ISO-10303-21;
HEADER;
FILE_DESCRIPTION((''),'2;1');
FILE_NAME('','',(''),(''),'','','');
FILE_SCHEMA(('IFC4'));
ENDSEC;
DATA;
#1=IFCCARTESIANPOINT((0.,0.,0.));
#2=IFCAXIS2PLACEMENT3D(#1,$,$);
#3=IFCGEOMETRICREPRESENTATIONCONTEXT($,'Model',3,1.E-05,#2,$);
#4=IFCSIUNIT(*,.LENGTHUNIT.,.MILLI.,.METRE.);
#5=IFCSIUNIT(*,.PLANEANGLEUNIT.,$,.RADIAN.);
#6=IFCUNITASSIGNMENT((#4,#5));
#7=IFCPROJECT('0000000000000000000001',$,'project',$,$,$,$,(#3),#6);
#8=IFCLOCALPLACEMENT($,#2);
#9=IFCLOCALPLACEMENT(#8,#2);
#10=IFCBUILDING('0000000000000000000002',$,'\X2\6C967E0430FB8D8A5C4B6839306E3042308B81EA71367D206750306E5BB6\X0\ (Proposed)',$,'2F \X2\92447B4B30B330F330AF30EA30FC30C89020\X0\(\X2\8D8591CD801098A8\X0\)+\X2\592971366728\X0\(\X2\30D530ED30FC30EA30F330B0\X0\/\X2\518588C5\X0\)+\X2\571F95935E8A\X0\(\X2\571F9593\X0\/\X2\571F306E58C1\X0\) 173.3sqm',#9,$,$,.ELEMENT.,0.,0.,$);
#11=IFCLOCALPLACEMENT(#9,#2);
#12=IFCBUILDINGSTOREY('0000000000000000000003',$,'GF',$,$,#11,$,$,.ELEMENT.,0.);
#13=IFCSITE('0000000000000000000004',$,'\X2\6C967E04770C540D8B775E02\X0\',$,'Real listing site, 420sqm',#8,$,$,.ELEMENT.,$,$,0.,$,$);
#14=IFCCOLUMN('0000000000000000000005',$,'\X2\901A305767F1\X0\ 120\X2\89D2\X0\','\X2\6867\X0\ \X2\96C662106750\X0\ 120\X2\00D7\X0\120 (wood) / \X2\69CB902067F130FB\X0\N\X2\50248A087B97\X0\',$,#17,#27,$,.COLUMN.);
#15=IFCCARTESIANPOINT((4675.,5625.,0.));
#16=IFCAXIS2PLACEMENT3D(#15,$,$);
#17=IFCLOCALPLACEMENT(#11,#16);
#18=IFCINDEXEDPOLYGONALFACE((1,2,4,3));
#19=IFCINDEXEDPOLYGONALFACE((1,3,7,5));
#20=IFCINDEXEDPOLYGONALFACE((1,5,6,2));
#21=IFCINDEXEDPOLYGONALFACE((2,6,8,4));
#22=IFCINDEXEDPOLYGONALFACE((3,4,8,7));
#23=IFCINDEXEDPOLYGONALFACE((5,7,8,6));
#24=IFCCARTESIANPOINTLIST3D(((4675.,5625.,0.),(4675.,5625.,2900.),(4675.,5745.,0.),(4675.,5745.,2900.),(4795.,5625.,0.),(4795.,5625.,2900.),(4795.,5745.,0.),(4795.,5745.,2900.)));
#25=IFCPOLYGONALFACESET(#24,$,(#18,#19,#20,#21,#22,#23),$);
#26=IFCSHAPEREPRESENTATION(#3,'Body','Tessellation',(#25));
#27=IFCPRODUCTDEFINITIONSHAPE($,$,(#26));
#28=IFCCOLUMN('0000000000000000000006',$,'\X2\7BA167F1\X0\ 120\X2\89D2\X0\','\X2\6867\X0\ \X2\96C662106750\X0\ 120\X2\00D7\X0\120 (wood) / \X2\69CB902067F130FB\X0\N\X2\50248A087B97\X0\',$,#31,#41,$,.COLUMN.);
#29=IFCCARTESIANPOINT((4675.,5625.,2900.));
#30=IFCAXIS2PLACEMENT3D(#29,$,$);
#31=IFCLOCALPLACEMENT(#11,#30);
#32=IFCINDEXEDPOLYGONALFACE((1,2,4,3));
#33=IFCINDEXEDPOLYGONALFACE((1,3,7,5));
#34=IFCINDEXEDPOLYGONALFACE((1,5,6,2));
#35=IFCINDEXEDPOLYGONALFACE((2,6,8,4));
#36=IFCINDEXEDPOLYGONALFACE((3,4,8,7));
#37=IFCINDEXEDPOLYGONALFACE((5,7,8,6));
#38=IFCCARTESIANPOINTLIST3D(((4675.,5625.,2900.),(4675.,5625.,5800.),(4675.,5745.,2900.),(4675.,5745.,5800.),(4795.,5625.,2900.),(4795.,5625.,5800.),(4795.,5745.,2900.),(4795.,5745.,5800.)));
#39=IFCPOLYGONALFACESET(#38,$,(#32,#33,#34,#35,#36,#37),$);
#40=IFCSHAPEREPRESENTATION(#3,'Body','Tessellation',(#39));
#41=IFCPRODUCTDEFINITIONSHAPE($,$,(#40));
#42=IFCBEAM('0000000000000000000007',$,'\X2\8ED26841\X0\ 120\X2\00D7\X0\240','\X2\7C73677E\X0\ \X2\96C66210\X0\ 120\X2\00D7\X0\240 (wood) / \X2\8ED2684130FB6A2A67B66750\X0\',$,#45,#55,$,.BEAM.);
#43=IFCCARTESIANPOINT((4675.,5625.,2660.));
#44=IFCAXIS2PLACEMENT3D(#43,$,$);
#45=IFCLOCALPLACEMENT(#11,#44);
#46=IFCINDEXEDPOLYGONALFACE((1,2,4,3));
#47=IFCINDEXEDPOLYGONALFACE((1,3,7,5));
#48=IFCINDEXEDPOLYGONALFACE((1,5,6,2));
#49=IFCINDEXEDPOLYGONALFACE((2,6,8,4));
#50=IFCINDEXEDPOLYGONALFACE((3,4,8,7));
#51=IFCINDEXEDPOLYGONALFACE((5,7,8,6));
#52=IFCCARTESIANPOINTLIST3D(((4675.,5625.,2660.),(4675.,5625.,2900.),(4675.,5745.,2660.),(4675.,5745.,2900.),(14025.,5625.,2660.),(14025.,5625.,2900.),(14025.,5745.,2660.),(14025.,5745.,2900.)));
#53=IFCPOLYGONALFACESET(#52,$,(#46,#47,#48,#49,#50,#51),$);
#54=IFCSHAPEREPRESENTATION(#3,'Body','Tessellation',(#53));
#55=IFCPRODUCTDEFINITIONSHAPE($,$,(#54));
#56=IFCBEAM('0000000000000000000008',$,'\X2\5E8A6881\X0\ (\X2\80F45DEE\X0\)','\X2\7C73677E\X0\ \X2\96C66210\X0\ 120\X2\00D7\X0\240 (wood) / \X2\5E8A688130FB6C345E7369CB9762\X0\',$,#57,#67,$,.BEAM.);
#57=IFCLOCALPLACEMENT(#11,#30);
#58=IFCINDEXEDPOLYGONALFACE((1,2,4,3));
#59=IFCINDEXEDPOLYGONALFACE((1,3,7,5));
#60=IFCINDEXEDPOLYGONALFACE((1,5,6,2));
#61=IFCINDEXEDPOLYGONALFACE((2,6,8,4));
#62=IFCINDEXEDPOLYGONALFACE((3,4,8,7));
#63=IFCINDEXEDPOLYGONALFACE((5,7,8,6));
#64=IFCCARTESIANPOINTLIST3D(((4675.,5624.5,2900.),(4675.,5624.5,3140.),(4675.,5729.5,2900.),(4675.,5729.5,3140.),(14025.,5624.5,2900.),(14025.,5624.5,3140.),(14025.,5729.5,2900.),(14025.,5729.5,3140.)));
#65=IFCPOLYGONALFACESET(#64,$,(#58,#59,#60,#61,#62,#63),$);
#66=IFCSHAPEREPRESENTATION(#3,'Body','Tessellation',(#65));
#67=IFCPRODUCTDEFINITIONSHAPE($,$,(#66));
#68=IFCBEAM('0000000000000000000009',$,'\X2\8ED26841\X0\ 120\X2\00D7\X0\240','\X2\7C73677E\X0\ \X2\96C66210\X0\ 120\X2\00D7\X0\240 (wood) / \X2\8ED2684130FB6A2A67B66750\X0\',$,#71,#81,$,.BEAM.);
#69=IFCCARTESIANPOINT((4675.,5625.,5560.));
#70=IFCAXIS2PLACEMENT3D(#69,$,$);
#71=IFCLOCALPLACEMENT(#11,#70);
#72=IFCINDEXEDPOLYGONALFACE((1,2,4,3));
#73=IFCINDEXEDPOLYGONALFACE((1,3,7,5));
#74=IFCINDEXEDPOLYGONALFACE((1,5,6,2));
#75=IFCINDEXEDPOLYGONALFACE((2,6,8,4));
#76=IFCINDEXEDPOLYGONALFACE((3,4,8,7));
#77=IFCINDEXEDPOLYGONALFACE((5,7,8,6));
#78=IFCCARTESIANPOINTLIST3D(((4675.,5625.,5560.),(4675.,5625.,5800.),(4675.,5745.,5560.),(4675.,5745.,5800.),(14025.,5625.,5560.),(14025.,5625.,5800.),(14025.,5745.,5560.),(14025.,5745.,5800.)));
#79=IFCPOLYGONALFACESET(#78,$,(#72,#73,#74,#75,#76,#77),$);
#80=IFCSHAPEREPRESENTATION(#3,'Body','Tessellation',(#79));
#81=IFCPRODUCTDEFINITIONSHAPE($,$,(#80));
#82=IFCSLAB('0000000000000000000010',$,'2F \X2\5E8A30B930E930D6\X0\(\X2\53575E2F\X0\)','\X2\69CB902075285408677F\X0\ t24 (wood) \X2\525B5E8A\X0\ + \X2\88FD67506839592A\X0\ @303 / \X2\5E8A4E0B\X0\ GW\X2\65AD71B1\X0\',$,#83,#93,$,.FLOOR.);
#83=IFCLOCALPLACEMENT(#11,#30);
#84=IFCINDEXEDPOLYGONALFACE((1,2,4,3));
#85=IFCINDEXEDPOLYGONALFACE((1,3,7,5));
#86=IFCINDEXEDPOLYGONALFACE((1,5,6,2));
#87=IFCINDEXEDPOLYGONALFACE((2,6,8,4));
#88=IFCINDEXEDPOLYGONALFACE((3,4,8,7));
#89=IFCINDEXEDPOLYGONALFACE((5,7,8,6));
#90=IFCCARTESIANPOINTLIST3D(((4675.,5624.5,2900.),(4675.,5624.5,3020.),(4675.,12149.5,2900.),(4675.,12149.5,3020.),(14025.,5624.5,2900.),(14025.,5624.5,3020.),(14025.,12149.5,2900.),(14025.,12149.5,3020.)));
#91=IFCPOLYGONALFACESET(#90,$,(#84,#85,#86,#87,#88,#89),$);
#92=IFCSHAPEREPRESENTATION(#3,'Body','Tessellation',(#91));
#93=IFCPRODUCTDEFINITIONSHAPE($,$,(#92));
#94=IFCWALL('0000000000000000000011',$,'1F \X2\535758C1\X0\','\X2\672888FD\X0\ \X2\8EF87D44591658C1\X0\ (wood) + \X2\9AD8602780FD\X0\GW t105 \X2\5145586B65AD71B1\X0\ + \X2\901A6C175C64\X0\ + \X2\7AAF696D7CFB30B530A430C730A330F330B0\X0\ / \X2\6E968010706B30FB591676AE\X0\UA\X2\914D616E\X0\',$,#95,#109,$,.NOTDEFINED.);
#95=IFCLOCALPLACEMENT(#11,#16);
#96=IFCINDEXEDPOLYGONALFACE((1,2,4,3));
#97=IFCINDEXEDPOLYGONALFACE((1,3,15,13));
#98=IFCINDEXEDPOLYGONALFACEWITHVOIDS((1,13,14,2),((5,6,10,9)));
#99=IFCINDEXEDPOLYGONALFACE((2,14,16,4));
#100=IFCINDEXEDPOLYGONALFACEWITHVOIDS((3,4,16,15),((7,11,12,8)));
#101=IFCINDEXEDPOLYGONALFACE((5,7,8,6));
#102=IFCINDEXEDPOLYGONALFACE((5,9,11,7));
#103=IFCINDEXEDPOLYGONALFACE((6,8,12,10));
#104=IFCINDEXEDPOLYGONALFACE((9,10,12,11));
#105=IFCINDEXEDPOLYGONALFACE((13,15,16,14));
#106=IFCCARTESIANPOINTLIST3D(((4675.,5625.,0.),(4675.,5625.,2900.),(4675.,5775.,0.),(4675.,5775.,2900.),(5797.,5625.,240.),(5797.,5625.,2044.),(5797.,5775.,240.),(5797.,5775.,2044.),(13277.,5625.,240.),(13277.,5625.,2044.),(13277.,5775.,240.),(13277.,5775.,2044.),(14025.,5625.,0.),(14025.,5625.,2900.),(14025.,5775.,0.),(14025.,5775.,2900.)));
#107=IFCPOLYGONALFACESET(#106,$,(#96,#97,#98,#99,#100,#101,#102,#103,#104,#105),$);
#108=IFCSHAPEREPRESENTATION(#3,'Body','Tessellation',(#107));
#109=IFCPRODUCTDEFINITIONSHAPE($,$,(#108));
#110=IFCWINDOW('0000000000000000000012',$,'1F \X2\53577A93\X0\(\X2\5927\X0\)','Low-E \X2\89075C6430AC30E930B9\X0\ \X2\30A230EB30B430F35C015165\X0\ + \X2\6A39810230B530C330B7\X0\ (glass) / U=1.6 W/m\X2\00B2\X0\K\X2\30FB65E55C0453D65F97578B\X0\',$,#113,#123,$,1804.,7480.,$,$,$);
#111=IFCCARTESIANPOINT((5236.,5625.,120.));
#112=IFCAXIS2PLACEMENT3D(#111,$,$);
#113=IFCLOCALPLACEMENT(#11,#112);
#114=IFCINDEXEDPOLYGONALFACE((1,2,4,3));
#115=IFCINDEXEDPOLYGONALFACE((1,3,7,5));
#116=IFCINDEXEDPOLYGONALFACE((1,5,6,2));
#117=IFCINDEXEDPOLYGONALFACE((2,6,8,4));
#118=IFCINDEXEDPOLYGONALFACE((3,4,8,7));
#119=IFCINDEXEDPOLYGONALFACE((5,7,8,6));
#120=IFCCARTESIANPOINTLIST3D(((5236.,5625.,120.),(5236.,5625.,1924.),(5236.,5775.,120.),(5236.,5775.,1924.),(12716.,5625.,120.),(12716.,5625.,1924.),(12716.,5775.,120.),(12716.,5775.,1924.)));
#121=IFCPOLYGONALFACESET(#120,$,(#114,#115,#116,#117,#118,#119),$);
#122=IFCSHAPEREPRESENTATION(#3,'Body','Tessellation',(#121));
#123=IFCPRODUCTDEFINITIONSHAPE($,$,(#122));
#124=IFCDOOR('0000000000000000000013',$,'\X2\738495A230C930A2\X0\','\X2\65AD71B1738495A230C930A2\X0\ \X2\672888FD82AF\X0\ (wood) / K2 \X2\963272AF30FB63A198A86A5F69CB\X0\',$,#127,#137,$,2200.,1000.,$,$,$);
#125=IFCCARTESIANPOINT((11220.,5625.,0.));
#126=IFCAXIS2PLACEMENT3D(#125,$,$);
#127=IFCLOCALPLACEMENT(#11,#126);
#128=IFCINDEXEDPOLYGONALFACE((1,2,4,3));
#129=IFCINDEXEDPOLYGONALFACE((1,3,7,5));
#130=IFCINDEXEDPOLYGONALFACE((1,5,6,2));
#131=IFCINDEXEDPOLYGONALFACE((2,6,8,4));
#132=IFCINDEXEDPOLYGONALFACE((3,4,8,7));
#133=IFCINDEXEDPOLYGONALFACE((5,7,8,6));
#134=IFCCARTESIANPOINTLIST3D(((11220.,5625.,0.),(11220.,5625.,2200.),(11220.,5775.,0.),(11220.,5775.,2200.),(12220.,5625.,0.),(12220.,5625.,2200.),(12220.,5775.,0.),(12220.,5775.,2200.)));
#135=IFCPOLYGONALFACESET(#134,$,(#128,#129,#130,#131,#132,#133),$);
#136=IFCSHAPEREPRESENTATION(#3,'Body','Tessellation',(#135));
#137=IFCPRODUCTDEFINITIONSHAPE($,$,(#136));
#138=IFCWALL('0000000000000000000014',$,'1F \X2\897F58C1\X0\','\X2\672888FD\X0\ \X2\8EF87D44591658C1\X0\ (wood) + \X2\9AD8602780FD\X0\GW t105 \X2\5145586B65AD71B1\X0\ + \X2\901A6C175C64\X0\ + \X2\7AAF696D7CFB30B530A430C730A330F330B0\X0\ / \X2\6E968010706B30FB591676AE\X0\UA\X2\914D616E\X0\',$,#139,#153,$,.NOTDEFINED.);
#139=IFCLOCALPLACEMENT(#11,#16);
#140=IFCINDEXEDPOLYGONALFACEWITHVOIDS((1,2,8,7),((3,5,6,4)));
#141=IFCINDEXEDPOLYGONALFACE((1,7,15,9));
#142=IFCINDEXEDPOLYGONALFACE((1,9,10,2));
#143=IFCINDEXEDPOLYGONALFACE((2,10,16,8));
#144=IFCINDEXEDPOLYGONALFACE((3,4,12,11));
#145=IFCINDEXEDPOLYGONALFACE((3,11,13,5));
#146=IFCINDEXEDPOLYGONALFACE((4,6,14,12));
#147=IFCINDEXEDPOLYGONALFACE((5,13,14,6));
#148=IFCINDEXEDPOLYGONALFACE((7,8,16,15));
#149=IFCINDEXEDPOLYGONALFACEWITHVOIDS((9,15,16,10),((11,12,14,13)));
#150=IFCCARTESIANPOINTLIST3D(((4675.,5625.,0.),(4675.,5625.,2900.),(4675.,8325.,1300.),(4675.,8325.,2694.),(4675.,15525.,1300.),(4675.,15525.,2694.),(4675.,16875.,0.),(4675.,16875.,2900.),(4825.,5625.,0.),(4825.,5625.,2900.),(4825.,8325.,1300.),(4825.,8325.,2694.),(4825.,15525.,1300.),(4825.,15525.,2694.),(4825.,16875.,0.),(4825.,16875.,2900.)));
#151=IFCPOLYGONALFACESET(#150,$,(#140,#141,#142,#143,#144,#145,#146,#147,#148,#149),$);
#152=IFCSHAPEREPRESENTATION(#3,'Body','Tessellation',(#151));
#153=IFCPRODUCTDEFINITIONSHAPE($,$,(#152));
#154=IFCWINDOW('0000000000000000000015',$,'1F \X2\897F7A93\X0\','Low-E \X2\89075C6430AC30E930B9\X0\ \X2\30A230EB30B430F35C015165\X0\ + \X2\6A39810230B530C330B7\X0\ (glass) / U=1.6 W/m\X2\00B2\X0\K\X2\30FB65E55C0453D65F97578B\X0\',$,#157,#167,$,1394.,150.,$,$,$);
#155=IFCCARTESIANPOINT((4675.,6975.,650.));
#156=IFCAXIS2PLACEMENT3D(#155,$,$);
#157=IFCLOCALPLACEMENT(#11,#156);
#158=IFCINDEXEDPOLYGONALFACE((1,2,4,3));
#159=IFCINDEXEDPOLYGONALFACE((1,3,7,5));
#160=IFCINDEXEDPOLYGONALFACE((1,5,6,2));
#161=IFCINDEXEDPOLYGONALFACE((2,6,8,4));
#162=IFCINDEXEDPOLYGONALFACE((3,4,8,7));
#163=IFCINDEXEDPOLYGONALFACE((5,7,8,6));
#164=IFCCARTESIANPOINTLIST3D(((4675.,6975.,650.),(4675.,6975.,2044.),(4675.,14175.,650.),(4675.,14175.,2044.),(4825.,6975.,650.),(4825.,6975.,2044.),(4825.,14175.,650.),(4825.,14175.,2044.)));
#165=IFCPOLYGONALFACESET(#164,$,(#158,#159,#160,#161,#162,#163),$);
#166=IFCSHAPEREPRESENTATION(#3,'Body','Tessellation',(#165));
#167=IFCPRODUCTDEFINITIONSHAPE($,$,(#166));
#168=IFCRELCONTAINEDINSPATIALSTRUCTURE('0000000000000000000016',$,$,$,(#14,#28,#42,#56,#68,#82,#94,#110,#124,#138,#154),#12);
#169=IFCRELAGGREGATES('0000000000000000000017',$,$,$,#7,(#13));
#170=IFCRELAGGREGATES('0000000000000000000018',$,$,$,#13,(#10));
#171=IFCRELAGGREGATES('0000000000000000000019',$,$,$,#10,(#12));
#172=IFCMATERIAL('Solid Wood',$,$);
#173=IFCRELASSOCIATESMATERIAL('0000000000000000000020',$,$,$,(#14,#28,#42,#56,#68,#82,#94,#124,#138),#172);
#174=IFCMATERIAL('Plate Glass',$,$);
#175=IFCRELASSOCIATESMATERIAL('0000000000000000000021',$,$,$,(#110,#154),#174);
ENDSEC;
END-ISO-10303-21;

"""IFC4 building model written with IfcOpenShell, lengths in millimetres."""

from ifc_helpers import new_model, si_unit, frame, frame_2d, origin, place, context, project, spatial, rectangle, extrude, material, element, fill, save


model = new_model("IFC4")

# Units and contexts
model_context = context("Model", 3, precision=1e-05, world=origin())
ifc_project = project(units=[si_unit("LENGTHUNIT", "METRE", prefix="MILLI"), si_unit("PLANEANGLEUNIT", "RADIAN")], contexts=[model_context])

# Site, building, storey
site_placement = place(None, origin())
site = spatial("IfcSite", under=ifc_project, at=site_placement, Name="沖縄県名護市", ObjectType="Real listing site, 420sqm", CompositionType="ELEMENT", RefElevation=0.0)
building_placement = place(site_placement, origin())
building = spatial("IfcBuilding", under=site, at=building_placement, Name="沖縄・越屋根のある自然素材の家 (Proposed)", ObjectType="2F 鉄筋コンクリート造(超重耐風)+天然木(フローリング/内装)+土間床(土間/土の壁) 173.3sqm", CompositionType="ELEMENT", ElevationOfRefHeight=0.0, ElevationOfTerrain=0.0)
storey_placement = place(building_placement, origin())
storey = spatial("IfcBuildingStorey", under=building, at=storey_placement, Name="GF", CompositionType="ELEMENT", Elevation=0.0)

# Columns
ifc_material_1 = material(Name="Solid Wood")
column_1_placement = place(storey_placement, frame((4675.0, 5625.0, 0.0)))
element("IfcColumn", 1, at=column_1_placement, inside=storey, material=ifc_material_1, Name="通し柱 120角", Description="桧 集成材 120×120 (wood) / 構造柱・N値計算", PredefinedType="COLUMN", context=model_context, shape_type="SweptSolid", body=[
    extrude(rectangle(XDim=120.0, YDim=120.0, at=frame_2d((60.0, 60.0))), frame((4675.0, 5625.0, 0.0)), (0.0, 0.0, 1.0), 2900.0),
])
column_2_placement = place(storey_placement, frame((4675.0, 5625.0, 2900.0)))
element("IfcColumn", 2, at=column_2_placement, inside=storey, material=ifc_material_1, Name="管柱 120角", Description="桧 集成材 120×120 (wood) / 構造柱・N値計算", PredefinedType="COLUMN", context=model_context, shape_type="SweptSolid", body=[
    extrude(rectangle(XDim=120.0, YDim=120.0, at=frame_2d((60.0, 60.0))), frame((4675.0, 5625.0, 2900.0)), (0.0, 0.0, 1.0), 2900.0),
])

# Beams
beam_1_placement = place(storey_placement, frame((4675.0, 5625.0, 2660.0)))
element("IfcBeam", 3, at=beam_1_placement, inside=storey, material=ifc_material_1, Name="軒桁 120×240", Description="米松 集成 120×240 (wood) / 軒桁・横架材", PredefinedType="BEAM", context=model_context, shape_type="SweptSolid", body=[
    extrude(rectangle(XDim=9350.0, YDim=120.0, at=frame_2d((4675.0, 60.0))), frame((4675.0, 5625.0, 2660.0)), (0.0, 0.0, 1.0), 240.0),
])
beam_2_placement = place(storey_placement, frame((4675.0, 5625.0, 2900.0)))
element("IfcBeam", 4, at=beam_2_placement, inside=storey, material=ifc_material_1, Name="床梁 (胴差)", Description="米松 集成 120×240 (wood) / 床梁・水平構面", PredefinedType="BEAM", context=model_context, shape_type="SweptSolid", body=[
    extrude(rectangle(XDim=9350.0, YDim=105.0, at=frame_2d((4675.0, 52.0))), frame((4675.0, 5625.0, 2900.0)), (0.0, 0.0, 1.0), 240.0),
])
beam_3_placement = place(storey_placement, frame((4675.0, 5625.0, 5560.0)))
element("IfcBeam", 5, at=beam_3_placement, inside=storey, material=ifc_material_1, Name="軒桁 120×240", Description="米松 集成 120×240 (wood) / 軒桁・横架材", PredefinedType="BEAM", context=model_context, shape_type="SweptSolid", body=[
    extrude(rectangle(XDim=9350.0, YDim=120.0, at=frame_2d((4675.0, 60.0))), frame((4675.0, 5625.0, 5560.0)), (0.0, 0.0, 1.0), 240.0),
])

# Slab
slab_1_placement = place(storey_placement, frame((4675.0, 5625.0, 2900.0)))
element("IfcSlab", 6, at=slab_1_placement, inside=storey, material=ifc_material_1, Name="2F 床スラブ(南帯)", Description="構造用合板 t24 (wood) 剛床 + 製材根太 @303 / 床下 GW断熱", PredefinedType="FLOOR", context=model_context, shape_type="SweptSolid", body=[
    extrude(rectangle(XDim=9350.0, YDim=6525.0, at=frame_2d((4675.0, 3262.0))), frame((4675.0, 5625.0, 2900.0)), (0.0, 0.0, 1.0), 120.0),
])

# Wall, openings, window, door
wall_1_placement = place(storey_placement, frame((4675.0, 5625.0, 0.0)))
wall_1 = element("IfcWall", 7, at=wall_1_placement, inside=storey, material=ifc_material_1, Name="1F 南壁", Description="木製 軸組外壁 (wood) + 高性能GW t105 充填断熱 + 通気層 + 窯業系サイディング / 準耐火・外皮UA配慮", PredefinedType="NOTDEFINED", context=model_context, shape_type="SweptSolid", body=[
    extrude(rectangle(XDim=9350.0, YDim=150.0, at=frame_2d((4675.0, 75.0))), frame((4675.0, 5625.0, 0.0)), (0.0, 0.0, 1.0), 2900.0),
])
opening_1_placement = place(storey_placement, frame((5236.0, 5625.0, 120.0)))
opening_1 = element("IfcOpeningElement", 8, at=opening_1_placement, cuts=wall_1, PredefinedType="NOTDEFINED", context=model_context, shape_type="SweptSolid", body=[
    extrude(rectangle(XDim=7480.0, YDim=150.0, at=frame_2d((3740.0, 75.0))), frame((5236.0, 5625.0, 120.0)), (0.0, 0.0, 1.0), 1804.0),
])
opening_2_placement = place(storey_placement, frame((11220.0, 5625.0, 0.0)))
opening_2 = element("IfcOpeningElement", 9, at=opening_2_placement, cuts=wall_1, PredefinedType="NOTDEFINED", context=model_context, shape_type="SweptSolid", body=[
    extrude(rectangle(XDim=1000.0, YDim=150.0, at=frame_2d((500.0, 75.0))), frame((11220.0, 5625.0, 0.0)), (0.0, 0.0, 1.0), 2200.0),
])
ifc_material_2 = material(Name="Plate Glass")
window_1_placement = place(storey_placement, frame((5236.0, 5625.0, 120.0)))
window_1 = element("IfcWindow", 10, at=window_1_placement, inside=storey, material=ifc_material_2, Name="1F 南窓(大)", Description="Low-E 複層ガラス アルゴン封入 + 樹脂サッシ (glass) / U=1.6 W/m²K・日射取得型", OverallHeight=1804.0, OverallWidth=7480.0, context=model_context, shape_type="SweptSolid", body=[
    extrude(rectangle(XDim=7480.0, YDim=150.0, at=frame_2d((3740.0, 75.0))), frame((5236.0, 5625.0, 120.0)), (0.0, 0.0, 1.0), 1804.0),
])
fill(opening_1, window_1)
door_placement = place(storey_placement, frame((11220.0, 5625.0, 0.0)))
door = element("IfcDoor", 11, at=door_placement, inside=storey, material=ifc_material_1, Name="玄関ドア", Description="断熱玄関ドア 木製芯 (wood) / K2 防犯・採風機構", OverallHeight=2200.0, OverallWidth=1000.0, context=model_context, shape_type="SweptSolid", body=[
    extrude(rectangle(XDim=1000.0, YDim=150.0, at=frame_2d((500.0, 75.0))), frame((11220.0, 5625.0, 0.0)), (0.0, 0.0, 1.0), 2200.0),
])
fill(opening_2, door)

# Wall, opening, window
wall_2_placement = place(storey_placement, frame((4675.0, 5625.0, 0.0)))
wall_2 = element("IfcWall", 12, at=wall_2_placement, inside=storey, material=ifc_material_1, Name="1F 西壁", Description="木製 軸組外壁 (wood) + 高性能GW t105 充填断熱 + 通気層 + 窯業系サイディング / 準耐火・外皮UA配慮", PredefinedType="NOTDEFINED", context=model_context, shape_type="SweptSolid", body=[
    extrude(rectangle(XDim=150.0, YDim=11250.0, at=frame_2d((75.0, 5625.0))), frame((4675.0, 5625.0, 0.0)), (0.0, 0.0, 1.0), 2900.0),
])
opening_3_placement = place(storey_placement, frame((4675.0, 6975.0, 650.0)))
opening_3 = element("IfcOpeningElement", 13, at=opening_3_placement, cuts=wall_2, PredefinedType="NOTDEFINED", context=model_context, shape_type="SweptSolid", body=[
    extrude(rectangle(XDim=150.0, YDim=7200.0, at=frame_2d((75.0, 3600.0))), frame((4675.0, 6975.0, 650.0)), (0.0, 0.0, 1.0), 1394.0),
])
window_2_placement = place(storey_placement, frame((4675.0, 6975.0, 650.0)))
window_2 = element("IfcWindow", 14, at=window_2_placement, inside=storey, material=ifc_material_2, Name="1F 西窓", Description="Low-E 複層ガラス アルゴン封入 + 樹脂サッシ (glass) / U=1.6 W/m²K・日射取得型", OverallHeight=1394.0, OverallWidth=150.0, context=model_context, shape_type="SweptSolid", body=[
    extrude(rectangle(XDim=150.0, YDim=7200.0, at=frame_2d((75.0, 3600.0))), frame((4675.0, 6975.0, 650.0)), (0.0, 0.0, 1.0), 1394.0),
])
fill(opening_3, window_2)

save(model, "model.ifc")
